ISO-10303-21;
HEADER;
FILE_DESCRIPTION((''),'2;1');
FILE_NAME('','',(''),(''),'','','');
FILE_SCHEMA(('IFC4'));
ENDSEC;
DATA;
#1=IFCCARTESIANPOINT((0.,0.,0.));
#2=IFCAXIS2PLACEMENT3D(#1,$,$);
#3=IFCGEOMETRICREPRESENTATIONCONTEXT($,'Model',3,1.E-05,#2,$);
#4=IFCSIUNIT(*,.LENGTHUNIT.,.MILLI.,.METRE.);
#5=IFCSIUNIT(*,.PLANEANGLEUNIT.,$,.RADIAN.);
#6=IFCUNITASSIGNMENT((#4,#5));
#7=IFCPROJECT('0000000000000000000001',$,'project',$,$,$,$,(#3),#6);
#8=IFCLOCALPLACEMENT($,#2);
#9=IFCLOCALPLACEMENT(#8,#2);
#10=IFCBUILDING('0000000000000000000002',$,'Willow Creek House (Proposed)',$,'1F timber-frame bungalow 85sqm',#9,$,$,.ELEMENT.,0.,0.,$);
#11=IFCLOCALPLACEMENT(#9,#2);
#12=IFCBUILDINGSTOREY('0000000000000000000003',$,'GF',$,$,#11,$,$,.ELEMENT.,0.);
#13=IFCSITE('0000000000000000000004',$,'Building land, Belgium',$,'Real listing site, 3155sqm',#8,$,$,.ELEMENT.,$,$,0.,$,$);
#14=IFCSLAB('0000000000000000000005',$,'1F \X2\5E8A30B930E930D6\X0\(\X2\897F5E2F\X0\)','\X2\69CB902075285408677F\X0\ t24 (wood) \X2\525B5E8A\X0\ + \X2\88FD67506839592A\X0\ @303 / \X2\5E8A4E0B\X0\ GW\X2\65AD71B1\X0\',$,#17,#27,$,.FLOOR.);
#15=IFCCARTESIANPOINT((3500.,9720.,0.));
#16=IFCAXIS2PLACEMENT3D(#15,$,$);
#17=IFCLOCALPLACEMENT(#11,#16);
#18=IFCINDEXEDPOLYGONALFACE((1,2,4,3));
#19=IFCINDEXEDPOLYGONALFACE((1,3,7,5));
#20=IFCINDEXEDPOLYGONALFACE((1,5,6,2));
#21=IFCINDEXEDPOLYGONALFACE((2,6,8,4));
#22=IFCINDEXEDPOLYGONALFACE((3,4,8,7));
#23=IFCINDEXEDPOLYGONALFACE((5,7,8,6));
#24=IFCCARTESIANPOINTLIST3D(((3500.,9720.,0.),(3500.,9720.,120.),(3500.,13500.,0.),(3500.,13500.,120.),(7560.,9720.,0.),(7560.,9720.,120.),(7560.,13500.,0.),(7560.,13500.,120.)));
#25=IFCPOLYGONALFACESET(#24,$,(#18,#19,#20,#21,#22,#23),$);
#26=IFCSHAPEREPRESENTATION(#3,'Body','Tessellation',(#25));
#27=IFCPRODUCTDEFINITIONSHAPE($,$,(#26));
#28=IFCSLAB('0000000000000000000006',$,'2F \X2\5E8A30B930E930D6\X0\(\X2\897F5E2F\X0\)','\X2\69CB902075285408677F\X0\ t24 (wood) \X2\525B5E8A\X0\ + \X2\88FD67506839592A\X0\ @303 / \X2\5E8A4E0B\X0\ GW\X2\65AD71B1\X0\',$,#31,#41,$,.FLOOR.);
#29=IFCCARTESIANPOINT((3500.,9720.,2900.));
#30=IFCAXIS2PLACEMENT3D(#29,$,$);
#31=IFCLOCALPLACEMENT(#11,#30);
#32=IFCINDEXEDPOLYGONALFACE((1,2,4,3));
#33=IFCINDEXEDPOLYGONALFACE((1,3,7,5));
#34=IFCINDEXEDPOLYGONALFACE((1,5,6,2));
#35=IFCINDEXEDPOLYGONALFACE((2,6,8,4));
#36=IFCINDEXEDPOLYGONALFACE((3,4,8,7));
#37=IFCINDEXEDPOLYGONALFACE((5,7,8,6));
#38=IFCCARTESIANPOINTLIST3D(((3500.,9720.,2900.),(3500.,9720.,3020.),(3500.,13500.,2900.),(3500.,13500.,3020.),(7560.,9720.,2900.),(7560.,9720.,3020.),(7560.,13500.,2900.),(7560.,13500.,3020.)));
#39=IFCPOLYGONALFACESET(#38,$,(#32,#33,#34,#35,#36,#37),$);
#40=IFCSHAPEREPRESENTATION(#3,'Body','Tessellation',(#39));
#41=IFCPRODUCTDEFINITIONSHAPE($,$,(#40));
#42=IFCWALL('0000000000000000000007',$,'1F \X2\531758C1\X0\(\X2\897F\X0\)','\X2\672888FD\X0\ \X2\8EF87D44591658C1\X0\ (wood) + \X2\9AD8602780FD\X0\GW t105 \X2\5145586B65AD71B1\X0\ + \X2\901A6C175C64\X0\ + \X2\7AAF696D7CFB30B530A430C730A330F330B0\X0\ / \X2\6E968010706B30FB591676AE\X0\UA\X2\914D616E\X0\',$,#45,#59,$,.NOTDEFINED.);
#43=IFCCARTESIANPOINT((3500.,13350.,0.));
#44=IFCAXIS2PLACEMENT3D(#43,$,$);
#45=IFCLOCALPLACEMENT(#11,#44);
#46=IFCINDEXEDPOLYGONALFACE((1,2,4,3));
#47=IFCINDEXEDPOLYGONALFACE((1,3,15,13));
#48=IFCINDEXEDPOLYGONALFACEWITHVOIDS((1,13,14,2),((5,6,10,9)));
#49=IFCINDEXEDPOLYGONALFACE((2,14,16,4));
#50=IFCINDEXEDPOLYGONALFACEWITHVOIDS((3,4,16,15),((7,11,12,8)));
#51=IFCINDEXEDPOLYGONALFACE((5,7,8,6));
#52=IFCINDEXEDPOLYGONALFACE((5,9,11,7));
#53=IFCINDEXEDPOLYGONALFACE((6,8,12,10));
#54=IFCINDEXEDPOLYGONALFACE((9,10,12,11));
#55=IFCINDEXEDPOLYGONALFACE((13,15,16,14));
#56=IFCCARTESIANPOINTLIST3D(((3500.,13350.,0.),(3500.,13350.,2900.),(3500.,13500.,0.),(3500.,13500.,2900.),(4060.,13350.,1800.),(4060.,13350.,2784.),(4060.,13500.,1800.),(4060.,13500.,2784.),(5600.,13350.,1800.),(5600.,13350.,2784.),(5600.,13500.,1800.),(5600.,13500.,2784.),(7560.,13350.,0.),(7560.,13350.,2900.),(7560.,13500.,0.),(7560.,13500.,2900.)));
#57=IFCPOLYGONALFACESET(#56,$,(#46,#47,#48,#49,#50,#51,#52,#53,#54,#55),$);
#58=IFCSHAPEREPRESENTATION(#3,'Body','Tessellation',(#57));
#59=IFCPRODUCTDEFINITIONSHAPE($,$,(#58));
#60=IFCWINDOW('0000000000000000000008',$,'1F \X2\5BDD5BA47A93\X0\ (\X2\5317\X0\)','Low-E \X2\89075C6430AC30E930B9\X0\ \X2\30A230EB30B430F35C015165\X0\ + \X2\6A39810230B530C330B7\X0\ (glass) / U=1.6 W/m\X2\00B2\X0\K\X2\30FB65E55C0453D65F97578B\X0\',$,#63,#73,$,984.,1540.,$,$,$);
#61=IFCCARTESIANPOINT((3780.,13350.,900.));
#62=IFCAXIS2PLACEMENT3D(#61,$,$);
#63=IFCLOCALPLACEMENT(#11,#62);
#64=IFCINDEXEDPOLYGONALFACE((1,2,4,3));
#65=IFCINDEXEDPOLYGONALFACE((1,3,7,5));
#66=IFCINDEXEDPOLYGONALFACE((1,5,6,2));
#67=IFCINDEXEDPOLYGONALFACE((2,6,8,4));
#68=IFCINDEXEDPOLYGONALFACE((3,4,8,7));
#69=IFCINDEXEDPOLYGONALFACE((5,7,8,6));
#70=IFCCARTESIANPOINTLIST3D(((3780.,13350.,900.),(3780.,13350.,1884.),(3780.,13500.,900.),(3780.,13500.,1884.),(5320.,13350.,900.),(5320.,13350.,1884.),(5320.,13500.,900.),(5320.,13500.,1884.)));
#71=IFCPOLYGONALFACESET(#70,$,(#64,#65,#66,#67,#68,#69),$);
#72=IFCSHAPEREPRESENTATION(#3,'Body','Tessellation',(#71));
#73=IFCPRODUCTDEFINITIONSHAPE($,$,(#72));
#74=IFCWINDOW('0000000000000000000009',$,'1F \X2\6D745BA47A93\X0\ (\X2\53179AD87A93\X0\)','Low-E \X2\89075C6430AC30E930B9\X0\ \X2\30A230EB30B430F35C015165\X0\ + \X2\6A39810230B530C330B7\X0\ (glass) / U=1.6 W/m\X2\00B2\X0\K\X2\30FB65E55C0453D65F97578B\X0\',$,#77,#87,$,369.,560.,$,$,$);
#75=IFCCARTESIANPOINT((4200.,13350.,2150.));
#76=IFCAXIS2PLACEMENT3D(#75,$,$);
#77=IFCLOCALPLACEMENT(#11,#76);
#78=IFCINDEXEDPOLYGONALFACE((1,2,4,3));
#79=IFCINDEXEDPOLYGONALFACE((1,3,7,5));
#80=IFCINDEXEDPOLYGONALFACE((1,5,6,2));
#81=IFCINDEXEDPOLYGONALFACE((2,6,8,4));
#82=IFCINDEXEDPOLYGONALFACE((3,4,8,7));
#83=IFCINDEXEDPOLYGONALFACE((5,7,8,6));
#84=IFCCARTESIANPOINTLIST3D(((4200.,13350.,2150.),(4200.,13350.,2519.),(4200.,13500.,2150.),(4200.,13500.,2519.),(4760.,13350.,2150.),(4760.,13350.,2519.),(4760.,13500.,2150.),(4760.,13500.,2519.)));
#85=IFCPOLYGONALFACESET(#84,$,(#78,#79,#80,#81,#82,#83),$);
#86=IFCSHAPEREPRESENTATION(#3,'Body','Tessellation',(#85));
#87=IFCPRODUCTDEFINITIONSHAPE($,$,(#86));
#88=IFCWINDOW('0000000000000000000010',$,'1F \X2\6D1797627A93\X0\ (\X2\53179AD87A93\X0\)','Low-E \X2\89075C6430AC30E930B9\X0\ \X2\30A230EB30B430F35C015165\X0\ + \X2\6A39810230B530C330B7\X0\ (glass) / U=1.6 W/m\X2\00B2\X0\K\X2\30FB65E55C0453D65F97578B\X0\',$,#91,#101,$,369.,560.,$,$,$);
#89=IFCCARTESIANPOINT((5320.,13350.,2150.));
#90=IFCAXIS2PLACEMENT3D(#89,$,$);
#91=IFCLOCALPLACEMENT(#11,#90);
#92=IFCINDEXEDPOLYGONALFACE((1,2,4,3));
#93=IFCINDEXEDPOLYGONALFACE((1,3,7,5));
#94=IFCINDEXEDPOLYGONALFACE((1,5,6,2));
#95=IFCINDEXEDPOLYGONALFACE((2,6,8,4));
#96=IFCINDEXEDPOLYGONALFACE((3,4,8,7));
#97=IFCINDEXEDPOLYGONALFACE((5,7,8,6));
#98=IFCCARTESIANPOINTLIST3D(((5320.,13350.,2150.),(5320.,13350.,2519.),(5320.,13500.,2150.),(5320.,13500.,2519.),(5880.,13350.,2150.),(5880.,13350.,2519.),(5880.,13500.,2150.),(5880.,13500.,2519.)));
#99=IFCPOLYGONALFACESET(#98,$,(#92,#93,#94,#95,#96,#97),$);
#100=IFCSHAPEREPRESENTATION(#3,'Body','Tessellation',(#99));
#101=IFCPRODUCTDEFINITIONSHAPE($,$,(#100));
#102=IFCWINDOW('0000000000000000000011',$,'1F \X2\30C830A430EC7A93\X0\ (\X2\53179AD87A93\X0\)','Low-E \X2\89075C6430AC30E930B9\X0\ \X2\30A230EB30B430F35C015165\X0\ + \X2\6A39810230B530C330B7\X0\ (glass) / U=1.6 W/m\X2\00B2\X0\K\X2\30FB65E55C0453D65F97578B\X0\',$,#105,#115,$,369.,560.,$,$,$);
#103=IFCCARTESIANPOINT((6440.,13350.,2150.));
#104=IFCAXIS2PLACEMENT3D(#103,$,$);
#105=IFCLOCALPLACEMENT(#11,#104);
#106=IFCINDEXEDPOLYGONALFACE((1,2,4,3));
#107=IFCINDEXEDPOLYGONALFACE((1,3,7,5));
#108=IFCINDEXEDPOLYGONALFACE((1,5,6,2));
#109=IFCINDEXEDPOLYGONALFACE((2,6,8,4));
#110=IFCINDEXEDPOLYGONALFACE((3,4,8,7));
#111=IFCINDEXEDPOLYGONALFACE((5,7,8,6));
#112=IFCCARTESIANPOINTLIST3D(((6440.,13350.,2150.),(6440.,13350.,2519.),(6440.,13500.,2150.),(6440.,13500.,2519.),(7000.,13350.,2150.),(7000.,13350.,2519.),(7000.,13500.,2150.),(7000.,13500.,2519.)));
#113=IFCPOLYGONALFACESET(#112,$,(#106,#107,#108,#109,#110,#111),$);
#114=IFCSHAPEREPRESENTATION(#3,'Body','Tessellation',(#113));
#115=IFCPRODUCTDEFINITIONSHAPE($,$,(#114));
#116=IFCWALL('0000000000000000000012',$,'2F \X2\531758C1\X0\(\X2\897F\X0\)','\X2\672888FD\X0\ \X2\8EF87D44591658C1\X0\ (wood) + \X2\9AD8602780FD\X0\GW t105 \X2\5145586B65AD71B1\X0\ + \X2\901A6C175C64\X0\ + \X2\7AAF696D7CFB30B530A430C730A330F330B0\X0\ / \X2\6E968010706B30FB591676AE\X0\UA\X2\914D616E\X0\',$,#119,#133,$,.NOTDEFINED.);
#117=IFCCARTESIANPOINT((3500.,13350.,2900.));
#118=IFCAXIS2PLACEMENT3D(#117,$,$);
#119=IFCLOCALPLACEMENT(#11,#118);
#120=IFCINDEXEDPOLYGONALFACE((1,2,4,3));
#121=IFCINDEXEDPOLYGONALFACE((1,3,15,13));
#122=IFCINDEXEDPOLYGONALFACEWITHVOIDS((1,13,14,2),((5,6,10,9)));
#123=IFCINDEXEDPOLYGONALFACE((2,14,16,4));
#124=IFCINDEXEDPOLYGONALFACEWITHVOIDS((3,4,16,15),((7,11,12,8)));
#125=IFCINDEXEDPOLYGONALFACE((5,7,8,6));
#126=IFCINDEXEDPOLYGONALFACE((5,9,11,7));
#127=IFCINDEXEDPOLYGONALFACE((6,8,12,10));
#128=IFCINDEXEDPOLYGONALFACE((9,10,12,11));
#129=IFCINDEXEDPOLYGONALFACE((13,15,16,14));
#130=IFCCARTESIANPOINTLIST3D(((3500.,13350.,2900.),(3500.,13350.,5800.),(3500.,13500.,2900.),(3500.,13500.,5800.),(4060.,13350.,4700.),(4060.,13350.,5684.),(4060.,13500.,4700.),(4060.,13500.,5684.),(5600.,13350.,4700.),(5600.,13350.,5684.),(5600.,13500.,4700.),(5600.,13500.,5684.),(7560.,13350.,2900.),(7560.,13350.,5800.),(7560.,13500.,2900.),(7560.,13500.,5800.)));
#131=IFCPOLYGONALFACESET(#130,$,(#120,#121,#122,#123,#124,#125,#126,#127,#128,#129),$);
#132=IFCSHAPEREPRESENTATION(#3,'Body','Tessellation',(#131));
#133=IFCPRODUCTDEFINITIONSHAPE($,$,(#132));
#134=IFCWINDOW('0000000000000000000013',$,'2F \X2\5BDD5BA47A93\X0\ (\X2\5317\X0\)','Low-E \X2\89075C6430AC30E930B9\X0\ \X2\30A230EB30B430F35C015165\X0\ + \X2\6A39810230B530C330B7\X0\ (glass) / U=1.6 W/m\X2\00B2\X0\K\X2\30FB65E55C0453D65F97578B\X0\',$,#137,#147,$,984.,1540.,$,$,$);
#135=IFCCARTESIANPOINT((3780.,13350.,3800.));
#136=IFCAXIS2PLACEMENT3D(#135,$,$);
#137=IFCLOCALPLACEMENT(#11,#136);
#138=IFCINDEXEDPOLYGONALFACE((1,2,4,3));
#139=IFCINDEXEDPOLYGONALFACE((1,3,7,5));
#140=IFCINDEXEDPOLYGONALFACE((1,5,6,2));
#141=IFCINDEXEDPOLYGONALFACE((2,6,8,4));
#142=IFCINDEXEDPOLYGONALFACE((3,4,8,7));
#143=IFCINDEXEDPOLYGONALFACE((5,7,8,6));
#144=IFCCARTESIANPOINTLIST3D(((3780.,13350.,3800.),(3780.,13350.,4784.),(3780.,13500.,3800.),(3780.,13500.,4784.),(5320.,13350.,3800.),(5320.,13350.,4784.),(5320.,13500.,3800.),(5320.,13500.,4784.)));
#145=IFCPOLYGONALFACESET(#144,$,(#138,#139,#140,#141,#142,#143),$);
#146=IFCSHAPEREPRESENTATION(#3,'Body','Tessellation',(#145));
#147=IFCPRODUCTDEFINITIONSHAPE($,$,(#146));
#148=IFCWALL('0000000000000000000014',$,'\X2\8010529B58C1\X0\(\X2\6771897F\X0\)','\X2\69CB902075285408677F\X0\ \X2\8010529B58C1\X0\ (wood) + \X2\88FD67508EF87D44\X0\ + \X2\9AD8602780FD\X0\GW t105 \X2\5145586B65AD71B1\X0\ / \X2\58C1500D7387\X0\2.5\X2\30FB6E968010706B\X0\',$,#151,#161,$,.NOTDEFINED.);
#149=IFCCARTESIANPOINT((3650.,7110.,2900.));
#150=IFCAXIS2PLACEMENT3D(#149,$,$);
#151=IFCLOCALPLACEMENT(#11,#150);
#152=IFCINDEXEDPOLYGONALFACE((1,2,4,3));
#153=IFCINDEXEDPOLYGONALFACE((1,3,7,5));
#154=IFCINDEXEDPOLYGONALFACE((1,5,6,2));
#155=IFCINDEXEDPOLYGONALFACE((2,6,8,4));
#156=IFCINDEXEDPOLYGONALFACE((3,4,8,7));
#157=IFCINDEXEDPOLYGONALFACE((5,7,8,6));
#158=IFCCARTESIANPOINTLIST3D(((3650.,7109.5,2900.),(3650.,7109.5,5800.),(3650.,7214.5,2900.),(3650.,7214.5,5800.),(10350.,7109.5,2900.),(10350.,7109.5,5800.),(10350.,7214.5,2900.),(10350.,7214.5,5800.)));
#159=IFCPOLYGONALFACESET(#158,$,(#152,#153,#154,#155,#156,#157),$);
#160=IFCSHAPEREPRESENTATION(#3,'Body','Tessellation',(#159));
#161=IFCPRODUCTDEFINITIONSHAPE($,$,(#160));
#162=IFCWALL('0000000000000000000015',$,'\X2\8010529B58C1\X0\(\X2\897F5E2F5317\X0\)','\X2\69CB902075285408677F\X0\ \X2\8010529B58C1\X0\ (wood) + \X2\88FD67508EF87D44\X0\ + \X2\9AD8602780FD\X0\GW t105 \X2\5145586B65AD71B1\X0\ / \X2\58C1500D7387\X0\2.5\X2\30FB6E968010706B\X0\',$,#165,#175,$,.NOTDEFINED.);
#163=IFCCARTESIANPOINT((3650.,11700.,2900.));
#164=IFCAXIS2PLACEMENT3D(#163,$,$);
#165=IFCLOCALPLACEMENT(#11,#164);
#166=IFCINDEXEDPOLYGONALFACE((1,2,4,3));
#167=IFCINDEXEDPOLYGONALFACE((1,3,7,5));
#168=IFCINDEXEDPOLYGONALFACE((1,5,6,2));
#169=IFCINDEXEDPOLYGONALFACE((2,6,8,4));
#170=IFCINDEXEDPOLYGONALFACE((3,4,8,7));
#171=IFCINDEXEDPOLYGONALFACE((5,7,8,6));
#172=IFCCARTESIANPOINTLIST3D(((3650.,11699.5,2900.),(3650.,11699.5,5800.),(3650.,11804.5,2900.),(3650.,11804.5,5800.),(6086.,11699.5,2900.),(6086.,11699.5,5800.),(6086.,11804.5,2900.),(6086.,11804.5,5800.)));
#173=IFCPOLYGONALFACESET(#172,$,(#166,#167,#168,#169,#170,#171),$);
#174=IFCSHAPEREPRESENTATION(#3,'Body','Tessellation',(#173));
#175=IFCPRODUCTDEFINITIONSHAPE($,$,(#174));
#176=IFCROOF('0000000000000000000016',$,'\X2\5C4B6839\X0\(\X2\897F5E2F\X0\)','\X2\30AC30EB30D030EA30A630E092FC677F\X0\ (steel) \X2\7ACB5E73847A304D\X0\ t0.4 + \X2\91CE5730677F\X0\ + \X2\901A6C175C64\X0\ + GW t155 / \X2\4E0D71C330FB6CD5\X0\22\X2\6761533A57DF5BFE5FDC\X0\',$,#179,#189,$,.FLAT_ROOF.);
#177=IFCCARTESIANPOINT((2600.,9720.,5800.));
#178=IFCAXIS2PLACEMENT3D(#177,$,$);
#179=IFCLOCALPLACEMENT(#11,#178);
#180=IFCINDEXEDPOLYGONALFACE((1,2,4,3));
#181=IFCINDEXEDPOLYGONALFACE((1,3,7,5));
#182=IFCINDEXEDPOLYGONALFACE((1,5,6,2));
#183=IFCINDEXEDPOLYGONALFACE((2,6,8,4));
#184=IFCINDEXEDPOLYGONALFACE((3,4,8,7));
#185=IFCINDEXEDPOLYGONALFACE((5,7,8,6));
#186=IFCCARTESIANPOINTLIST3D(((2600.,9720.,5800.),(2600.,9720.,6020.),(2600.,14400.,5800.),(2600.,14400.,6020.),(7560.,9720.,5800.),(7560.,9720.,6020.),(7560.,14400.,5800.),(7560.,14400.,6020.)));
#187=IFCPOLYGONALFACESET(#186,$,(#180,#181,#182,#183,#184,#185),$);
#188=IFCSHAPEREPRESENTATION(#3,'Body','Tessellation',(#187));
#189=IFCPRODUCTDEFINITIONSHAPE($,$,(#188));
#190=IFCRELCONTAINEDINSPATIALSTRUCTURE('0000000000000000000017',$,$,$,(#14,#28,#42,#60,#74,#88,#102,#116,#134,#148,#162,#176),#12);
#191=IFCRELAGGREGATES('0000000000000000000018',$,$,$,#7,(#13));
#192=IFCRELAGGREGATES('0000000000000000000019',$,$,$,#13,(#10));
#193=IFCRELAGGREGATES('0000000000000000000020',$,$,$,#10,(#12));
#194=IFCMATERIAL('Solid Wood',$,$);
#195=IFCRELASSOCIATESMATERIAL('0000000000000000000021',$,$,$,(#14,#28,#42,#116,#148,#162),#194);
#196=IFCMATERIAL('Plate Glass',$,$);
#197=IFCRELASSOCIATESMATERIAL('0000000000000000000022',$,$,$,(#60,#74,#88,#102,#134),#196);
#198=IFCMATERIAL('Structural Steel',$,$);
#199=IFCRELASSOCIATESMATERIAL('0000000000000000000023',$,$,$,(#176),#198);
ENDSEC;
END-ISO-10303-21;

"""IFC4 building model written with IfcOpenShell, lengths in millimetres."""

from ifc_helpers import new_model, si_unit, frame, frame_2d, origin, place, context, project, spatial, rectangle, extrude, material, element, fill, save


model = new_model("IFC4")

# Units and contexts
model_context = context("Model", 3, precision=1e-05, world=origin())
ifc_project = project(units=[si_unit("LENGTHUNIT", "METRE", prefix="MILLI"), si_unit("PLANEANGLEUNIT", "RADIAN")], contexts=[model_context])

# Site, building, storey
site_placement = place(None, origin())
site = spatial("IfcSite", under=ifc_project, at=site_placement, Name="Building land, Belgium", ObjectType="Real listing site, 3155sqm", CompositionType="ELEMENT", RefElevation=0.0)
building_placement = place(site_placement, origin())
building = spatial("IfcBuilding", under=site, at=building_placement, Name="Willow Creek House (Proposed)", ObjectType="1F timber-frame bungalow 85sqm", CompositionType="ELEMENT", ElevationOfRefHeight=0.0, ElevationOfTerrain=0.0)
storey_placement = place(building_placement, origin())
storey = spatial("IfcBuildingStorey", under=building, at=storey_placement, Name="GF", CompositionType="ELEMENT", Elevation=0.0)

# Slabs
ifc_material_1 = material(Name="Solid Wood")
slab_1_placement = place(storey_placement, frame((3500.0, 9720.0, 0.0)))
element("IfcSlab", 1, at=slab_1_placement, inside=storey, material=ifc_material_1, Name="1F 床スラブ(西帯)", Description="構造用合板 t24 (wood) 剛床 + 製材根太 @303 / 床下 GW断熱", PredefinedType="FLOOR", context=model_context, shape_type="SweptSolid", body=[
    extrude(rectangle(XDim=4060.0, YDim=3780.0, at=frame_2d((2030.0, 1890.0))), frame((3500.0, 9720.0, 0.0)), (0.0, 0.0, 1.0), 120.0),
])
slab_2_placement = place(storey_placement, frame((3500.0, 9720.0, 2900.0)))
element("IfcSlab", 2, at=slab_2_placement, inside=storey, material=ifc_material_1, Name="2F 床スラブ(西帯)", Description="構造用合板 t24 (wood) 剛床 + 製材根太 @303 / 床下 GW断熱", PredefinedType="FLOOR", context=model_context, shape_type="SweptSolid", body=[
    extrude(rectangle(XDim=4060.0, YDim=3780.0, at=frame_2d((2030.0, 1890.0))), frame((3500.0, 9720.0, 2900.0)), (0.0, 0.0, 1.0), 120.0),
])

# Wall, openings, windows
wall_1_placement = place(storey_placement, frame((3500.0, 13350.0, 0.0)))
wall_1 = element("IfcWall", 3, at=wall_1_placement, inside=storey, material=ifc_material_1, Name="1F 北壁(西)", Description="木製 軸組外壁 (wood) + 高性能GW t105 充填断熱 + 通気層 + 窯業系サイディング / 準耐火・外皮UA配慮", PredefinedType="NOTDEFINED", context=model_context, shape_type="SweptSolid", body=[
    extrude(rectangle(XDim=4060.0, YDim=150.0, at=frame_2d((2030.0, 75.0))), frame((3500.0, 13350.0, 0.0)), (0.0, 0.0, 1.0), 2900.0),
])
opening_1_placement = place(storey_placement, frame((3780.0, 13350.0, 900.0)))
opening_1 = element("IfcOpeningElement", 4, at=opening_1_placement, cuts=wall_1, PredefinedType="NOTDEFINED", context=model_context, shape_type="SweptSolid", body=[
    extrude(rectangle(XDim=1540.0, YDim=150.0, at=frame_2d((770.0, 75.0))), frame((3780.0, 13350.0, 900.0)), (0.0, 0.0, 1.0), 984.0),
])
opening_2_placement = place(storey_placement, frame((4200.0, 13350.0, 2150.0)))
opening_2 = element("IfcOpeningElement", 5, at=opening_2_placement, cuts=wall_1, PredefinedType="NOTDEFINED", context=model_context, shape_type="SweptSolid", body=[
    extrude(rectangle(XDim=560.0, YDim=150.0, at=frame_2d((280.0, 75.0))), frame((4200.0, 13350.0, 2150.0)), (0.0, 0.0, 1.0), 369.0),
])
opening_3_placement = place(storey_placement, frame((5320.0, 13350.0, 2150.0)))
opening_3 = element("IfcOpeningElement", 6, at=opening_3_placement, cuts=wall_1, PredefinedType="NOTDEFINED", context=model_context, shape_type="SweptSolid", body=[
    extrude(rectangle(XDim=560.0, YDim=150.0, at=frame_2d((280.0, 75.0))), frame((5320.0, 13350.0, 2150.0)), (0.0, 0.0, 1.0), 369.0),
])
opening_4_placement = place(storey_placement, frame((6440.0, 13350.0, 2150.0)))
opening_4 = element("IfcOpeningElement", 7, at=opening_4_placement, cuts=wall_1, PredefinedType="NOTDEFINED", context=model_context, shape_type="SweptSolid", body=[
    extrude(rectangle(XDim=560.0, YDim=150.0, at=frame_2d((280.0, 75.0))), frame((6440.0, 13350.0, 2150.0)), (0.0, 0.0, 1.0), 369.0),
])
ifc_material_2 = material(Name="Plate Glass")
window_1_placement = place(storey_placement, frame((3780.0, 13350.0, 900.0)))
window_1 = element("IfcWindow", 8, at=window_1_placement, inside=storey, material=ifc_material_2, Name="1F 寝室窓 (北)", Description="Low-E 複層ガラス アルゴン封入 + 樹脂サッシ (glass) / U=1.6 W/m²K・日射取得型", OverallHeight=984.0, OverallWidth=1540.0, context=model_context, shape_type="SweptSolid", body=[
    extrude(rectangle(XDim=1540.0, YDim=150.0, at=frame_2d((770.0, 75.0))), frame((3780.0, 13350.0, 900.0)), (0.0, 0.0, 1.0), 984.0),
])
fill(opening_1, window_1)
window_2_placement = place(storey_placement, frame((4200.0, 13350.0, 2150.0)))
window_2 = element("IfcWindow", 9, at=window_2_placement, inside=storey, material=ifc_material_2, Name="1F 浴室窓 (北高窓)", Description="Low-E 複層ガラス アルゴン封入 + 樹脂サッシ (glass) / U=1.6 W/m²K・日射取得型", OverallHeight=369.0, OverallWidth=560.0, context=model_context, shape_type="SweptSolid", body=[
    extrude(rectangle(XDim=560.0, YDim=150.0, at=frame_2d((280.0, 75.0))), frame((4200.0, 13350.0, 2150.0)), (0.0, 0.0, 1.0), 369.0),
])
fill(opening_2, window_2)
window_3_placement = place(storey_placement, frame((5320.0, 13350.0, 2150.0)))
window_3 = element("IfcWindow", 10, at=window_3_placement, inside=storey, material=ifc_material_2, Name="1F 洗面窓 (北高窓)", Description="Low-E 複層ガラス アルゴン封入 + 樹脂サッシ (glass) / U=1.6 W/m²K・日射取得型", OverallHeight=369.0, OverallWidth=560.0, context=model_context, shape_type="SweptSolid", body=[
    extrude(rectangle(XDim=560.0, YDim=150.0, at=frame_2d((280.0, 75.0))), frame((5320.0, 13350.0, 2150.0)), (0.0, 0.0, 1.0), 369.0),
])
fill(opening_3, window_3)
window_4_placement = place(storey_placement, frame((6440.0, 13350.0, 2150.0)))
window_4 = element("IfcWindow", 11, at=window_4_placement, inside=storey, material=ifc_material_2, Name="1F トイレ窓 (北高窓)", Description="Low-E 複層ガラス アルゴン封入 + 樹脂サッシ (glass) / U=1.6 W/m²K・日射取得型", OverallHeight=369.0, OverallWidth=560.0, context=model_context, shape_type="SweptSolid", body=[
    extrude(rectangle(XDim=560.0, YDim=150.0, at=frame_2d((280.0, 75.0))), frame((6440.0, 13350.0, 2150.0)), (0.0, 0.0, 1.0), 369.0),
])
fill(opening_4, window_4)

# Wall, opening, window
wall_2_placement = place(storey_placement, frame((3500.0, 13350.0, 2900.0)))
wall_2 = element("IfcWall", 12, at=wall_2_placement, inside=storey, material=ifc_material_1, Name="2F 北壁(西)", Description="木製 軸組外壁 (wood) + 高性能GW t105 充填断熱 + 通気層 + 窯業系サイディング / 準耐火・外皮UA配慮", PredefinedType="NOTDEFINED", context=model_context, shape_type="SweptSolid", body=[
    extrude(rectangle(XDim=4060.0, YDim=150.0, at=frame_2d((2030.0, 75.0))), frame((3500.0, 13350.0, 2900.0)), (0.0, 0.0, 1.0), 2900.0),
])
opening_5_placement = place(storey_placement, frame((3780.0, 13350.0, 3800.0)))
opening_5 = element("IfcOpeningElement", 13, at=opening_5_placement, cuts=wall_2, PredefinedType="NOTDEFINED", context=model_context, shape_type="SweptSolid", body=[
    extrude(rectangle(XDim=1540.0, YDim=150.0, at=frame_2d((770.0, 75.0))), frame((3780.0, 13350.0, 3800.0)), (0.0, 0.0, 1.0), 984.0),
])
window_5_placement = place(storey_placement, frame((3780.0, 13350.0, 3800.0)))
window_5 = element("IfcWindow", 14, at=window_5_placement, inside=storey, material=ifc_material_2, Name="2F 寝室窓 (北)", Description="Low-E 複層ガラス アルゴン封入 + 樹脂サッシ (glass) / U=1.6 W/m²K・日射取得型", OverallHeight=984.0, OverallWidth=1540.0, context=model_context, shape_type="SweptSolid", body=[
    extrude(rectangle(XDim=1540.0, YDim=150.0, at=frame_2d((770.0, 75.0))), frame((3780.0, 13350.0, 3800.0)), (0.0, 0.0, 1.0), 984.0),
])
fill(opening_5, window_5)

# Walls
wall_3_placement = place(storey_placement, frame((3650.0, 7110.0, 2900.0)))
element("IfcWall", 15, at=wall_3_placement, inside=storey, material=ifc_material_1, Name="耐力壁(東西)", Description="構造用合板 耐力壁 (wood) + 製材軸組 + 高性能GW t105 充填断熱 / 壁倍率2.5・準耐火", PredefinedType="NOTDEFINED", context=model_context, shape_type="SweptSolid", body=[
    extrude(rectangle(XDim=6700.0, YDim=105.0, at=frame_2d((3350.0, 52.0))), frame((3650.0, 7110.0, 2900.0)), (0.0, 0.0, 1.0), 2900.0),
])
wall_4_placement = place(storey_placement, frame((3650.0, 11700.0, 2900.0)))
element("IfcWall", 16, at=wall_4_placement, inside=storey, material=ifc_material_1, Name="耐力壁(西帯北)", Description="構造用合板 耐力壁 (wood) + 製材軸組 + 高性能GW t105 充填断熱 / 壁倍率2.5・準耐火", PredefinedType="NOTDEFINED", context=model_context, shape_type="SweptSolid", body=[
    extrude(rectangle(XDim=2436.0, YDim=105.0, at=frame_2d((1218.0, 52.0))), frame((3650.0, 11700.0, 2900.0)), (0.0, 0.0, 1.0), 2900.0),
])

# Roof
ifc_material_3 = material(Name="Structural Steel")
for number, where, name in (
    (17, (2600.0, 9720.0, 5800.0), "屋根(西帯)"),
):
    element("IfcRoof", number, at=place(storey_placement, frame(where)), inside=storey, material=ifc_material_3, Name=name, Description="ガルバリウム鋼板 (steel) 立平葺き t0.4 + 野地板 + 通気層 + GW t155 / 不燃・法22条区域対応", PredefinedType="FLAT_ROOF", context=model_context, shape_type="SweptSolid", body=[
        extrude(rectangle(XDim=4960.0, YDim=4680.0, at=frame_2d((2480.0, 2340.0))), frame((2600.0, 9720.0, 5800.0)), (0.0, 0.0, 1.0), 220.0),
    ])

save(model, "model.ifc")
